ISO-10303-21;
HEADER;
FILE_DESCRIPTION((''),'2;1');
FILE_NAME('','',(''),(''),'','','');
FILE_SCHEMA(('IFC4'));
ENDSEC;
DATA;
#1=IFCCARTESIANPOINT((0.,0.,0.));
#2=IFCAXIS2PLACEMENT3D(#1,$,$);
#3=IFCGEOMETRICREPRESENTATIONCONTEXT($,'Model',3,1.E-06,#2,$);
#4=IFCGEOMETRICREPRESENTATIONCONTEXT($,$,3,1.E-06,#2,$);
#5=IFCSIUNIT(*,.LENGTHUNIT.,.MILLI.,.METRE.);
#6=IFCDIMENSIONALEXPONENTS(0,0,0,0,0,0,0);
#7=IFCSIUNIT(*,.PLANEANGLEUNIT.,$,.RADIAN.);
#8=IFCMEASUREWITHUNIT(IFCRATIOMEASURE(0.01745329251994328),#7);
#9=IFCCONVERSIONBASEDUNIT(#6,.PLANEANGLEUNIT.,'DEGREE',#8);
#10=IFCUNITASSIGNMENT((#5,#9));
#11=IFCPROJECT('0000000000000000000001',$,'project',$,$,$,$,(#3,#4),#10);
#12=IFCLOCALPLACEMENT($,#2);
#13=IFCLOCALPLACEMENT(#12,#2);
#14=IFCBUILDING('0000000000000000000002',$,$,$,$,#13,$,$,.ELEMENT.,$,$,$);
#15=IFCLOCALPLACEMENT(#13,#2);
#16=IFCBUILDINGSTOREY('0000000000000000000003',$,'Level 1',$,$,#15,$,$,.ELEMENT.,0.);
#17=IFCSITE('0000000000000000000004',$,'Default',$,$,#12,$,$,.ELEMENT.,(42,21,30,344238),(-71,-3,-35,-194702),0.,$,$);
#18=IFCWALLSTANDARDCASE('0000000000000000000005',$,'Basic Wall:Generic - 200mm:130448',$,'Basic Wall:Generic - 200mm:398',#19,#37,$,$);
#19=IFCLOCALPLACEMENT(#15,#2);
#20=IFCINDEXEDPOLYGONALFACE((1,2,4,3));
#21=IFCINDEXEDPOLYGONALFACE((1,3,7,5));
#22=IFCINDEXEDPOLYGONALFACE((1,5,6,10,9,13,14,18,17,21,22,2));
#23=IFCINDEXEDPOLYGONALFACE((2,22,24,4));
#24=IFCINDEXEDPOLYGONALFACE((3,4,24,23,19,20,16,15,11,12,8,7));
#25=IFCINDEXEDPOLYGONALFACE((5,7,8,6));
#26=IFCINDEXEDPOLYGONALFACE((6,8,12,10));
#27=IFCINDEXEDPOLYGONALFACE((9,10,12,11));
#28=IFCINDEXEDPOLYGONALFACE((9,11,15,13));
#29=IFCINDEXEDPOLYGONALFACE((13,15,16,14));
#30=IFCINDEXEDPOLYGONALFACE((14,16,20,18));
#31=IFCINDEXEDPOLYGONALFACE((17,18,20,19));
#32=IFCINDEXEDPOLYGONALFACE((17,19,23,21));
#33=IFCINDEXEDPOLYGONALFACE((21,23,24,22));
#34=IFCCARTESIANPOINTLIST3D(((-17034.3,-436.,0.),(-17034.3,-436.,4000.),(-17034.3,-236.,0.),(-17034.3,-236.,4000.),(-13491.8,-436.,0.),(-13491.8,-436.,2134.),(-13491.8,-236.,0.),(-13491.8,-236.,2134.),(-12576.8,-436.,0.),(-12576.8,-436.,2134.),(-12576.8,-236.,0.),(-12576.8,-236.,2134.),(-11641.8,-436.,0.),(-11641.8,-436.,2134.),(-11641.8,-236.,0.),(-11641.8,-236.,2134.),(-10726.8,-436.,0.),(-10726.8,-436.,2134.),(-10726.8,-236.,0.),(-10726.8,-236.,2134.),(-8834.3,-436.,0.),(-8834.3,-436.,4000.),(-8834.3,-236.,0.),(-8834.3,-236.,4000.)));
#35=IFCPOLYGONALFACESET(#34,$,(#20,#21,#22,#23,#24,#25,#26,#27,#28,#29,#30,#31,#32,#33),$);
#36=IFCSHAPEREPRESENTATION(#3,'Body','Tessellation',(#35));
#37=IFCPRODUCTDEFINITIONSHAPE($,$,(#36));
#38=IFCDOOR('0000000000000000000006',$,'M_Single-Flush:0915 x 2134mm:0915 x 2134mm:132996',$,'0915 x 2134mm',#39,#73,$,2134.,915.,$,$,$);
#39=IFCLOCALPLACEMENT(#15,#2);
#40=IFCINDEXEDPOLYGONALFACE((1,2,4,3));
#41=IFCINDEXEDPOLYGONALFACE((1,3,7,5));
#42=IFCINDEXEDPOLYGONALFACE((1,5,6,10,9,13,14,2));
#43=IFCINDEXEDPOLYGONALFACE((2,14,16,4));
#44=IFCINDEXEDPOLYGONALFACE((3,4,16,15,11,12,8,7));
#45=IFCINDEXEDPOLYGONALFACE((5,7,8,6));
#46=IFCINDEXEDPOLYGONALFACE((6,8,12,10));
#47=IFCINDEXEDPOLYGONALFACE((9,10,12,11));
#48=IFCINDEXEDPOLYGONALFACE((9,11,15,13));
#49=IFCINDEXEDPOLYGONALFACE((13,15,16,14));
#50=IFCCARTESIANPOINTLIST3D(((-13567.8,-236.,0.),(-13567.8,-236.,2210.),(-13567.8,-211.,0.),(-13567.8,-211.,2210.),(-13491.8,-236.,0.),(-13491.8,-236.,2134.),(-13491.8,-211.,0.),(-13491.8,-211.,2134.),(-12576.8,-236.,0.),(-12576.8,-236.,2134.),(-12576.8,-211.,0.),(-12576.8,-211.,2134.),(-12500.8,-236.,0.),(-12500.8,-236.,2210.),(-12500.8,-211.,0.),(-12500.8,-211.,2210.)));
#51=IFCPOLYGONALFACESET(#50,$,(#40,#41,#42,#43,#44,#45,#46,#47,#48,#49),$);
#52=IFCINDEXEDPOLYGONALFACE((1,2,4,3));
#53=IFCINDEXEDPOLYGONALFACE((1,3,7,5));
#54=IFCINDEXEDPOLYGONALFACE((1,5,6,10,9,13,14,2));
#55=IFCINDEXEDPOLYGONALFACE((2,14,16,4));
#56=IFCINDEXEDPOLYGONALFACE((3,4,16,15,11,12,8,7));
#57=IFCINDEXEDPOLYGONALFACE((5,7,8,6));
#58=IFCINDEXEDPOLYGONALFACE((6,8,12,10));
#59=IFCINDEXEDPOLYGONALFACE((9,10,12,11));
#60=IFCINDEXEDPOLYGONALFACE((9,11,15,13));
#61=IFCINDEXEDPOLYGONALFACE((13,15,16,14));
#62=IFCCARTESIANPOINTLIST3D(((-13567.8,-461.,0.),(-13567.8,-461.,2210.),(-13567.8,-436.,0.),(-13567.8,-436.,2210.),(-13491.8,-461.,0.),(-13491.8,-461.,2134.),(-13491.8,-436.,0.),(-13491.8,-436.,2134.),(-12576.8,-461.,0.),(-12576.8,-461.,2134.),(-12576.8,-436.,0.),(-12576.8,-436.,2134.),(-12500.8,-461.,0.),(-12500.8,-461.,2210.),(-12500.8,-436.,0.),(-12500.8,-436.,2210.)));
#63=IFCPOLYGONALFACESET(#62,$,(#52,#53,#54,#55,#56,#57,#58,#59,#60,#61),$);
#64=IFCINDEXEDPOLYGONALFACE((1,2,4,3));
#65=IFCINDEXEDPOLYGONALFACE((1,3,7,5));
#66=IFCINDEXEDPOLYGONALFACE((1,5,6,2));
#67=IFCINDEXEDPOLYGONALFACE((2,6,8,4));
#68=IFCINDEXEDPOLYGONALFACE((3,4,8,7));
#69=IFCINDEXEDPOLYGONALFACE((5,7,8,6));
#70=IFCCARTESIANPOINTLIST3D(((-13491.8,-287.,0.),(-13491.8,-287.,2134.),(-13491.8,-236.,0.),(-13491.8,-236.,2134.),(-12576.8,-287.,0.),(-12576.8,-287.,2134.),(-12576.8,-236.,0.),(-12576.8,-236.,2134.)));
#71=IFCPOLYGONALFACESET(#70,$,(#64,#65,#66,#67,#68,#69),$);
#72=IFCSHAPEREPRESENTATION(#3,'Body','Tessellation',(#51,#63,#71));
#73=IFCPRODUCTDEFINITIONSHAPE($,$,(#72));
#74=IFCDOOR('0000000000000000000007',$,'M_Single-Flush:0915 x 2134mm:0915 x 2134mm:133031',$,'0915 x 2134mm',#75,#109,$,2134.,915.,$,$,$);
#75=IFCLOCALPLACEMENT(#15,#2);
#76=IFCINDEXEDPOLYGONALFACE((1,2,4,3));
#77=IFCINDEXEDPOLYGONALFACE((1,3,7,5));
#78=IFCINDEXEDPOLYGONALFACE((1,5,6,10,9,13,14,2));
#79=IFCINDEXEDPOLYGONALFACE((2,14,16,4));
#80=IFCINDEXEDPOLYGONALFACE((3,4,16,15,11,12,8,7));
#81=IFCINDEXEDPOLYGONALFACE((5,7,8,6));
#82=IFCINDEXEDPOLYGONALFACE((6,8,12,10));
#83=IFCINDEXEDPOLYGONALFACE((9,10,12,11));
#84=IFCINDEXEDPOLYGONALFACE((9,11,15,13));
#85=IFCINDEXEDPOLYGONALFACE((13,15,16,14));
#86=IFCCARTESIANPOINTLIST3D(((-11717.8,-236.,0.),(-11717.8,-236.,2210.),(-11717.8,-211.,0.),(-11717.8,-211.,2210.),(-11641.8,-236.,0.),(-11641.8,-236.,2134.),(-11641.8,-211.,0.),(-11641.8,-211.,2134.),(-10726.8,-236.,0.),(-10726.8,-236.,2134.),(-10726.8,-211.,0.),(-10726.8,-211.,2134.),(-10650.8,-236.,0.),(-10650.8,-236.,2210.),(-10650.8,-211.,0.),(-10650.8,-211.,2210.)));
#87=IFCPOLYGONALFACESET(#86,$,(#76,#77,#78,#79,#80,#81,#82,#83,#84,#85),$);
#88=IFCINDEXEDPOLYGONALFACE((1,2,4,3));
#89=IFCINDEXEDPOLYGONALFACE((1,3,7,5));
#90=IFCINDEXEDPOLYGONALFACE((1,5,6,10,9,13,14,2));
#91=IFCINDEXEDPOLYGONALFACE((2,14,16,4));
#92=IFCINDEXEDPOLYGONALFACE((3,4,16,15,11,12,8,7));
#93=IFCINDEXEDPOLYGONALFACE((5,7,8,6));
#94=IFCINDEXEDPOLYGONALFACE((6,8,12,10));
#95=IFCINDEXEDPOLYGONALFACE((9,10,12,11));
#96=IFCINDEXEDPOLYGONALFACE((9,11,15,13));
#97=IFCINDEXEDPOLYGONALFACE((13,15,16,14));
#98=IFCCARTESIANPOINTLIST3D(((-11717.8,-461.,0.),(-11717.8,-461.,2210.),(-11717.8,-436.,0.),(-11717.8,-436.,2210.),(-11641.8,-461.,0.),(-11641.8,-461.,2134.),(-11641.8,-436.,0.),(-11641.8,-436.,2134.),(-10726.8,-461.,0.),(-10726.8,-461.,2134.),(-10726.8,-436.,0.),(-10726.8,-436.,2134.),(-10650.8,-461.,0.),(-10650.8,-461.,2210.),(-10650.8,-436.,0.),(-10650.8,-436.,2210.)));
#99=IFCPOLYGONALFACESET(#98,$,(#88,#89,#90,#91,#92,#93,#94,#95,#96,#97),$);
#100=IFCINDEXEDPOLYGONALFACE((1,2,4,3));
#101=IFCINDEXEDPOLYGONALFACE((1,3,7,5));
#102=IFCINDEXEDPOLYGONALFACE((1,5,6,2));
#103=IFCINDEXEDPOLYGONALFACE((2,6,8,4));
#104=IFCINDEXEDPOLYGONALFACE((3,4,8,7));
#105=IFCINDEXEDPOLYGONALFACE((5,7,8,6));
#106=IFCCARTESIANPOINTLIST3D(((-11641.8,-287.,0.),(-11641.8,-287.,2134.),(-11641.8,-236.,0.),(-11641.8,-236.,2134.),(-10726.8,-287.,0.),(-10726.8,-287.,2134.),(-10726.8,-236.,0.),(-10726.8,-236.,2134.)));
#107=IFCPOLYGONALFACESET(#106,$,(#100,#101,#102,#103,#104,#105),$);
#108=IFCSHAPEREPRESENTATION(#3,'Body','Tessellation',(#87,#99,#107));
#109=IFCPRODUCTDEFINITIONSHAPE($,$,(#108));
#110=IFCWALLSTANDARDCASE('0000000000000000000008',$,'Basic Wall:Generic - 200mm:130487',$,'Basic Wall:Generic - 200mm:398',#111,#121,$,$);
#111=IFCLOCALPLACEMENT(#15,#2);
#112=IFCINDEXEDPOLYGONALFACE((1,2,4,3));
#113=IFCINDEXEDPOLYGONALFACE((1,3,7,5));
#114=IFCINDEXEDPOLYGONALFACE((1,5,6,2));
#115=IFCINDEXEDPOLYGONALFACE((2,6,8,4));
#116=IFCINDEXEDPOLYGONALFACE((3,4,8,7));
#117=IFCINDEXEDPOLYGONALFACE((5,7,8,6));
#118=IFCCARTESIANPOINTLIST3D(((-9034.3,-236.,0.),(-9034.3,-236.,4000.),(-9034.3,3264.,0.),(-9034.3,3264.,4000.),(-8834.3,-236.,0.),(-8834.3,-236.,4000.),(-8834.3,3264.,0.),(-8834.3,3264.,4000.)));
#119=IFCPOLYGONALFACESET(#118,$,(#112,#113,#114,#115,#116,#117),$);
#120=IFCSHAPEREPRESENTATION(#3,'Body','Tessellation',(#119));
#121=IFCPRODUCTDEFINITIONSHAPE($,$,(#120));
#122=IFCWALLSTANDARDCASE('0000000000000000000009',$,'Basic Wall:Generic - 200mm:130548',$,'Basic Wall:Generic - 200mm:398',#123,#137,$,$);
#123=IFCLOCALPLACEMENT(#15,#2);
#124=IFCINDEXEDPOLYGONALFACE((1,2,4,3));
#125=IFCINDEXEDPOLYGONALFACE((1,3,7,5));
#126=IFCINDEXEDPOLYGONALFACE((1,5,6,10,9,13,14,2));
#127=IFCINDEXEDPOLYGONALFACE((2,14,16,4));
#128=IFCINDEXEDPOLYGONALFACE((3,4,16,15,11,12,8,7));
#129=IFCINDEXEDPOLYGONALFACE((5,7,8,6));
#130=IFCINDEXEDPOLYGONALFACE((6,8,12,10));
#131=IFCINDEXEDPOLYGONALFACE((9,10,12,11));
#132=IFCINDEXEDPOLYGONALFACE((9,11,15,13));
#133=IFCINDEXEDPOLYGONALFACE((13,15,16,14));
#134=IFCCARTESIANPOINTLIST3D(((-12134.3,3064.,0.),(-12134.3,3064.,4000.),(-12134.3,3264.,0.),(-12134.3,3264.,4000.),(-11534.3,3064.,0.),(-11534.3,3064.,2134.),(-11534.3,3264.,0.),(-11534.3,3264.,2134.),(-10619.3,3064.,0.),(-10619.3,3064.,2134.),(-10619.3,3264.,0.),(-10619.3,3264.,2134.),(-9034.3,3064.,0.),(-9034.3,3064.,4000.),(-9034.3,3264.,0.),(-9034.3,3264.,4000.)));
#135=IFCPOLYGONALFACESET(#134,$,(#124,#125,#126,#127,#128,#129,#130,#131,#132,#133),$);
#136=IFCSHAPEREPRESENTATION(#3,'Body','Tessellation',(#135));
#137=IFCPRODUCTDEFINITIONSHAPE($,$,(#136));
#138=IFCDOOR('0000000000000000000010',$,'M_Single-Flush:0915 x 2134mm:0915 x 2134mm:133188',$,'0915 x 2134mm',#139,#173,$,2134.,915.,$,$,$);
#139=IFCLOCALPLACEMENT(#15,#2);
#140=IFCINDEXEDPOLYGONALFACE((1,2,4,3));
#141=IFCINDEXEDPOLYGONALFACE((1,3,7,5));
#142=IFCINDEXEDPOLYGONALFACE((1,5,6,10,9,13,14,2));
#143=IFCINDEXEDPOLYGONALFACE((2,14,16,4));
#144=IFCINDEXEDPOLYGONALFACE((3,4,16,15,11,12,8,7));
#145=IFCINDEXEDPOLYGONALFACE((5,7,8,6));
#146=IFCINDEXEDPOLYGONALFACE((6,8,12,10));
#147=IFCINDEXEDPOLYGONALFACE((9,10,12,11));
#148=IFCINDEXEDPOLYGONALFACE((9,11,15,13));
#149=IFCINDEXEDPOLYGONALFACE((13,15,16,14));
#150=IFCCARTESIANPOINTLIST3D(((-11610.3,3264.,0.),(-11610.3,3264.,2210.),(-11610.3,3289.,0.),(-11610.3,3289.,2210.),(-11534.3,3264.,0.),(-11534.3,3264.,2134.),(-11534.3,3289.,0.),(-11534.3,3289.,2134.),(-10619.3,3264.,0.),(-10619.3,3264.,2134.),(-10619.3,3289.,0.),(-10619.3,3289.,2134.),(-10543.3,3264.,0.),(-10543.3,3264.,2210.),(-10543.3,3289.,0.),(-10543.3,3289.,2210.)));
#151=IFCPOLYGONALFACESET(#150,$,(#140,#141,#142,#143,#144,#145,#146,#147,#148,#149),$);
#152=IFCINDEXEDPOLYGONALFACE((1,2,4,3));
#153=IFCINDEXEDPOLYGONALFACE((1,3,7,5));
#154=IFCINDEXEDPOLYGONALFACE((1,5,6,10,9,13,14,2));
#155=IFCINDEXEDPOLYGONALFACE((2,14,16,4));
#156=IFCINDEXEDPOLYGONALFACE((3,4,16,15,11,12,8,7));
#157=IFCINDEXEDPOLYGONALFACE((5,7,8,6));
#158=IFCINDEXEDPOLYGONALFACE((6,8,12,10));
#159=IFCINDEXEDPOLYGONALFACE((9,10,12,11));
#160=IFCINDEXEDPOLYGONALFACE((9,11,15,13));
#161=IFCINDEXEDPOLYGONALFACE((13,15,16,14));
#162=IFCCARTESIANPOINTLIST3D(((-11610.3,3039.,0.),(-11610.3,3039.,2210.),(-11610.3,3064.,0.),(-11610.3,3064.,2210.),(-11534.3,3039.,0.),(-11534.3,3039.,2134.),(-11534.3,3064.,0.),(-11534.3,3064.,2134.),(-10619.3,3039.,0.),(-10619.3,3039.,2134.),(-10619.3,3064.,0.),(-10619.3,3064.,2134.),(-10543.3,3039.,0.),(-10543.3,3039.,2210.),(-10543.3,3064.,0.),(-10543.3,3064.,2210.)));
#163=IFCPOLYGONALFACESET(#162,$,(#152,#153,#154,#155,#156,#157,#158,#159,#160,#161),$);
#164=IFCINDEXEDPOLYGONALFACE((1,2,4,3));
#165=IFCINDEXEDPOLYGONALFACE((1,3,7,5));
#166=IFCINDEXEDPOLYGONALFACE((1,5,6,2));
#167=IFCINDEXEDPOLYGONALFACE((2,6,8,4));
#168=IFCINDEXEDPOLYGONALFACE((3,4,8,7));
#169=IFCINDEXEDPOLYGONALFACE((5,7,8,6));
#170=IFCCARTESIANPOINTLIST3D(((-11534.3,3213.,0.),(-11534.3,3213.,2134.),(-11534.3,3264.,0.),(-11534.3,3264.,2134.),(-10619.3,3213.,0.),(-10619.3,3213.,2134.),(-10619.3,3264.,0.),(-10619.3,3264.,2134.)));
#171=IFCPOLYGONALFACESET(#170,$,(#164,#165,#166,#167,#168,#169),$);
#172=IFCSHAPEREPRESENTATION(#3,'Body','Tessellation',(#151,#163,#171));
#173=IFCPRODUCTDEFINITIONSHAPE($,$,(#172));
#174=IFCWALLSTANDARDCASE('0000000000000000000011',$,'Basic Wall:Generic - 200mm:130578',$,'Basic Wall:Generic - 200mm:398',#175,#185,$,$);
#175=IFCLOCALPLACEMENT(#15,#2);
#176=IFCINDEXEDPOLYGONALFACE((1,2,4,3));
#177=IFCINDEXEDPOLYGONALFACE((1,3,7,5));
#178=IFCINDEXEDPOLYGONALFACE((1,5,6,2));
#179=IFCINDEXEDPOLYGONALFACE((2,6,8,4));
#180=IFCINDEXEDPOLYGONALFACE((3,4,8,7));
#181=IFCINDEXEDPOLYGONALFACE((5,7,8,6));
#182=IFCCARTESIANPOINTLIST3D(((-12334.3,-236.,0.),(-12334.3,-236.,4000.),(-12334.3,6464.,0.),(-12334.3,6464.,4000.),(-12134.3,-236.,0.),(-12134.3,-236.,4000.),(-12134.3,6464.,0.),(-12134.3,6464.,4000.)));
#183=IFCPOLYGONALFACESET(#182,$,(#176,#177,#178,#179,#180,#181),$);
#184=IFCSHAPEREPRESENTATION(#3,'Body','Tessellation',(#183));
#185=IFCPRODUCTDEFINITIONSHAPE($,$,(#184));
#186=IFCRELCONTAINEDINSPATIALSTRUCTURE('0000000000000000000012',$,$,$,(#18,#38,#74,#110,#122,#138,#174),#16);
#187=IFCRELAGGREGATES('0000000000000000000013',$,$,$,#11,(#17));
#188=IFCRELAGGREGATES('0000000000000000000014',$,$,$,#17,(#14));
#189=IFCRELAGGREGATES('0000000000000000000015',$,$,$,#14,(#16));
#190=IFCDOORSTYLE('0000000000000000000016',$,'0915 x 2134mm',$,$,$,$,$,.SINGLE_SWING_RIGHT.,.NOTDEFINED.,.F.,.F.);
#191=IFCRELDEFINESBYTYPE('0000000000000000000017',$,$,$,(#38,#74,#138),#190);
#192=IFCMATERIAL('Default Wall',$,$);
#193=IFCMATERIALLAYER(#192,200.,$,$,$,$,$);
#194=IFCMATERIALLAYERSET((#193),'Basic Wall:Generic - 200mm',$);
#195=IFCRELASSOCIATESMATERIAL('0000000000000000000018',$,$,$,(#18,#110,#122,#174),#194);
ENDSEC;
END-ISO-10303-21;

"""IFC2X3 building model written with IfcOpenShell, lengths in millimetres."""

from ifc_helpers import new_model, entity, si_unit, converted_unit, frame, frame_2d, origin, origin_2d_with_axis, place, context, project, spatial, polyline, rectangle, outline, extrude, source, transform, mapped, material, layer, layer_set, layer_usage, type_object, type_shapes, element, fill, save


model = new_model("IFC2X3")

# Units and contexts
model_context = context("Model", 3, precision=1e-06, world=origin())
context_of_model = context(None, 3, precision=1e-06, world=origin())
ifc_project = project(units=[si_unit("LENGTHUNIT", "METRE", prefix="MILLI"), converted_unit("PLANEANGLEUNIT", "DEGREE", entity("IfcRatioMeasure", 0.01745329251994328), si_unit("PLANEANGLEUNIT", "RADIAN"), dimensions=[0, 0, 0, 0, 0, 0, 0])], contexts=[model_context, context_of_model])

# Site, building, storey
site_placement = place(None, origin())
site = spatial("IfcSite", under=ifc_project, at=site_placement, Name="Default", CompositionType="ELEMENT", RefLatitude=(42, 21, 30, 344238), RefLongitude=(-71, -3, -35, -194702), RefElevation=0.0)
building_placement = place(site_placement, origin())
building = spatial("IfcBuilding", under=site, at=building_placement, CompositionType="ELEMENT")
storey_placement = place(building_placement, origin())
storey = spatial("IfcBuildingStorey", under=building, at=storey_placement, Name="Level 1", CompositionType="ELEMENT", Elevation=0.0)

# Shared definitions
ifc_material_1 = material(Name="Default Wall")
ifc_layer_1 = layer(ifc_material_1, 200.0)
ifc_layer_set_1 = layer_set([ifc_layer_1], Name="Basic Wall:Generic - 200mm")
door_style = type_object("IfcDoorStyle", Name="0915 x 2134mm", ConstructionType="NOTDEFINED", OperationType="SINGLE_SWING_RIGHT", ParameterTakesPrecedence=False, Sizeable=False)
shared_shape_1 = source(origin(), model_context, "Body", "SweptSolid", [
    extrude(outline(polyline([(-533.5, -1124.0), (533.5, -1124.0), (533.5, 1086.0), (457.5, 1086.0), (457.5, -1048.0), (-457.5, -1048.0), (-457.5, 1086.0), (-533.5, 1086.0), (-533.5, -1124.0)])), frame((457.5, 200.0, 1086.0), z_axis=(0.0, 1.0, 0.0), x_axis=(1.0, 0.0, 0.0)), (0.0, 0.0, 1.0), 25.0),
    extrude(outline(polyline([(-1124.0, -533.5), (1086.0, -533.5), (1086.0, -457.5), (-1048.0, -457.5), (-1048.0, 457.5), (1086.0, 457.5), (1086.0, 533.5), (-1124.0, 533.5), (-1124.0, -533.5)])), frame((457.5, -25.0, 1086.0), z_axis=(0.0, 1.0, 0.0), x_axis=(0.0, 0.0, -1.0)), (0.0, 0.0, 1.0), 25.0),
    extrude(rectangle(XDim=51.0, YDim=915.0, at=origin_2d_with_axis()), frame((457.5, 174.5, 0.0), z_axis=(0.0, 0.0, 1.0), x_axis=(0.0, 1.0, 0.0)), (0.0, 0.0, 1.0), 2134.0),
])
type_shapes(door_style, [shared_shape_1])

# Wall, openings, doors
ifc_layer_usage_1 = layer_usage(ifc_layer_set_1, "AXIS2", "NEGATIVE", 100.0)
wall_1_placement = place(storey_placement, frame((-17034.3, -336.0, 0.0)))
wall_1 = element("IfcWallStandardCase", 1, at=wall_1_placement, inside=storey, material=ifc_layer_usage_1, Name="Basic Wall:Generic - 200mm:130448", ObjectType="Basic Wall:Generic - 200mm:398", context=model_context, shape_type="SweptSolid", body=[
    extrude(rectangle(XDim=8200.0, YDim=200.0, at=frame_2d((4100.0, 0.0), x_axis=(-1.0, 0.0))), origin(), (0.0, 0.0, 1.0), 4000.0),
])
opening_1_placement = place(wall_1_placement, frame((3542.5, -100.0, 0.0)))
opening_1 = element("IfcOpeningElement", 2, at=opening_1_placement, cuts=wall_1, ObjectType="Opening", context=model_context, shape_type="SweptSolid", body=[
    extrude(rectangle(XDim=915.0, YDim=2134.0, at=frame_2d((1067.0, 457.5), x_axis=(0.0, 1.0))), frame((0.0, 0.0, 0.0), z_axis=(0.0, 1.0, 0.0), x_axis=(0.0, 0.0, 1.0)), (0.0, 0.0, 1.0), 200.0),
])
opening_2_placement = place(wall_1_placement, frame((5392.5, -100.0, 0.0)))
opening_2 = element("IfcOpeningElement", 3, at=opening_2_placement, cuts=wall_1, ObjectType="Opening", context=model_context, shape_type="SweptSolid", body=[
    extrude(rectangle(XDim=915.0, YDim=2134.0, at=frame_2d((1067.0, 457.5), x_axis=(0.0, 1.0))), frame((0.0, 0.0, 0.0), z_axis=(0.0, 1.0, 0.0), x_axis=(0.0, 0.0, 1.0)), (0.0, 0.0, 1.0), 200.0),
])
door_1_placement = place(opening_1_placement, origin())
door_1 = element("IfcDoor", 4, at=door_1_placement, inside=storey, type_object=door_style, Name="M_Single-Flush:0915 x 2134mm:0915 x 2134mm:132996", ObjectType="0915 x 2134mm", OverallHeight=2134.0, OverallWidth=915.0, context=model_context, shape_type="MappedRepresentation", body=[
    mapped(shared_shape_1, transform((0.0, 0.0, 0.0), scale=1.0)),
])
fill(opening_1, door_1)
door_2_placement = place(opening_2_placement, origin())
door_2 = element("IfcDoor", 5, at=door_2_placement, inside=storey, type_object=door_style, Name="M_Single-Flush:0915 x 2134mm:0915 x 2134mm:133031", ObjectType="0915 x 2134mm", OverallHeight=2134.0, OverallWidth=915.0, context=model_context, shape_type="MappedRepresentation", body=[
    mapped(shared_shape_1, transform((0.0, 0.0, 0.0), scale=1.0)),
])
fill(opening_2, door_2)

# Wall
ifc_layer_usage_2 = layer_usage(ifc_layer_set_1, "AXIS2", "NEGATIVE", 100.0)
wall_2_placement = place(storey_placement, frame((-8934.3, -236.0, 0.0), z_axis=(0.0, 0.0, 1.0), x_axis=(0.0, 1.0, 0.0)))
element("IfcWallStandardCase", 6, at=wall_2_placement, inside=storey, material=ifc_layer_usage_2, Name="Basic Wall:Generic - 200mm:130487", ObjectType="Basic Wall:Generic - 200mm:398", context=model_context, shape_type="SweptSolid", body=[
    extrude(rectangle(XDim=3500.0, YDim=200.0, at=frame_2d((1750.0, 0.0), x_axis=(-1.0, 0.0))), origin(), (0.0, 0.0, 1.0), 4000.0),
])

# Wall, opening, door
ifc_layer_usage_3 = layer_usage(ifc_layer_set_1, "AXIS2", "NEGATIVE", 100.0)
wall_3_placement = place(storey_placement, frame((-9034.3, 3164.0, 0.0), z_axis=(0.0, 0.0, 1.0), x_axis=(-1.0, 0.0, 0.0)))
wall_3 = element("IfcWallStandardCase", 7, at=wall_3_placement, inside=storey, material=ifc_layer_usage_3, Name="Basic Wall:Generic - 200mm:130548", ObjectType="Basic Wall:Generic - 200mm:398", context=model_context, shape_type="SweptSolid", body=[
    extrude(rectangle(XDim=3100.0, YDim=200.0, at=frame_2d((1550.0, 0.0), x_axis=(-1.0, 0.0))), origin(), (0.0, 0.0, 1.0), 4000.0),
])
opening_3_placement = place(wall_3_placement, frame((2500.0, 100.0, 0.0)))
opening_3 = element("IfcOpeningElement", 8, at=opening_3_placement, cuts=wall_3, ObjectType="Opening", context=model_context, shape_type="SweptSolid", body=[
    extrude(rectangle(XDim=915.0, YDim=2134.0, at=frame_2d((1067.0, 457.5), x_axis=(0.0, 1.0))), frame((0.0, 0.0, 0.0), z_axis=(0.0, -1.0, 0.0), x_axis=(0.0, 0.0, 1.0)), (0.0, 0.0, 1.0), 200.0),
])
door_3_placement = place(opening_3_placement, frame((0.0, 0.0, 0.0), z_axis=(0.0, 0.0, 1.0), x_axis=(-1.0, 0.0, 0.0)))
door_3 = element("IfcDoor", 9, at=door_3_placement, inside=storey, type_object=door_style, Name="M_Single-Flush:0915 x 2134mm:0915 x 2134mm:133188", ObjectType="0915 x 2134mm", OverallHeight=2134.0, OverallWidth=915.0, context=model_context, shape_type="MappedRepresentation", body=[
    mapped(shared_shape_1, transform((0.0, 0.0, 0.0), scale=1.0)),
])
fill(opening_3, door_3)

# Wall
ifc_layer_usage_4 = layer_usage(ifc_layer_set_1, "AXIS2", "POSITIVE", -100.0)
wall_4_placement = place(storey_placement, frame((-12234.3, 6464.0, 0.0), z_axis=(0.0, 0.0, 1.0), x_axis=(0.0, -1.0, 0.0)))
element("IfcWallStandardCase", 10, at=wall_4_placement, inside=storey, material=ifc_layer_usage_4, Name="Basic Wall:Generic - 200mm:130578", ObjectType="Basic Wall:Generic - 200mm:398", context=model_context, shape_type="SweptSolid", body=[
    extrude(rectangle(XDim=6700.0, YDim=200.0, at=frame_2d((3350.0, 0.0), x_axis=(-1.0, 0.0))), origin(), (0.0, 0.0, 1.0), 4000.0),
])

save(model, "model.ifc")
